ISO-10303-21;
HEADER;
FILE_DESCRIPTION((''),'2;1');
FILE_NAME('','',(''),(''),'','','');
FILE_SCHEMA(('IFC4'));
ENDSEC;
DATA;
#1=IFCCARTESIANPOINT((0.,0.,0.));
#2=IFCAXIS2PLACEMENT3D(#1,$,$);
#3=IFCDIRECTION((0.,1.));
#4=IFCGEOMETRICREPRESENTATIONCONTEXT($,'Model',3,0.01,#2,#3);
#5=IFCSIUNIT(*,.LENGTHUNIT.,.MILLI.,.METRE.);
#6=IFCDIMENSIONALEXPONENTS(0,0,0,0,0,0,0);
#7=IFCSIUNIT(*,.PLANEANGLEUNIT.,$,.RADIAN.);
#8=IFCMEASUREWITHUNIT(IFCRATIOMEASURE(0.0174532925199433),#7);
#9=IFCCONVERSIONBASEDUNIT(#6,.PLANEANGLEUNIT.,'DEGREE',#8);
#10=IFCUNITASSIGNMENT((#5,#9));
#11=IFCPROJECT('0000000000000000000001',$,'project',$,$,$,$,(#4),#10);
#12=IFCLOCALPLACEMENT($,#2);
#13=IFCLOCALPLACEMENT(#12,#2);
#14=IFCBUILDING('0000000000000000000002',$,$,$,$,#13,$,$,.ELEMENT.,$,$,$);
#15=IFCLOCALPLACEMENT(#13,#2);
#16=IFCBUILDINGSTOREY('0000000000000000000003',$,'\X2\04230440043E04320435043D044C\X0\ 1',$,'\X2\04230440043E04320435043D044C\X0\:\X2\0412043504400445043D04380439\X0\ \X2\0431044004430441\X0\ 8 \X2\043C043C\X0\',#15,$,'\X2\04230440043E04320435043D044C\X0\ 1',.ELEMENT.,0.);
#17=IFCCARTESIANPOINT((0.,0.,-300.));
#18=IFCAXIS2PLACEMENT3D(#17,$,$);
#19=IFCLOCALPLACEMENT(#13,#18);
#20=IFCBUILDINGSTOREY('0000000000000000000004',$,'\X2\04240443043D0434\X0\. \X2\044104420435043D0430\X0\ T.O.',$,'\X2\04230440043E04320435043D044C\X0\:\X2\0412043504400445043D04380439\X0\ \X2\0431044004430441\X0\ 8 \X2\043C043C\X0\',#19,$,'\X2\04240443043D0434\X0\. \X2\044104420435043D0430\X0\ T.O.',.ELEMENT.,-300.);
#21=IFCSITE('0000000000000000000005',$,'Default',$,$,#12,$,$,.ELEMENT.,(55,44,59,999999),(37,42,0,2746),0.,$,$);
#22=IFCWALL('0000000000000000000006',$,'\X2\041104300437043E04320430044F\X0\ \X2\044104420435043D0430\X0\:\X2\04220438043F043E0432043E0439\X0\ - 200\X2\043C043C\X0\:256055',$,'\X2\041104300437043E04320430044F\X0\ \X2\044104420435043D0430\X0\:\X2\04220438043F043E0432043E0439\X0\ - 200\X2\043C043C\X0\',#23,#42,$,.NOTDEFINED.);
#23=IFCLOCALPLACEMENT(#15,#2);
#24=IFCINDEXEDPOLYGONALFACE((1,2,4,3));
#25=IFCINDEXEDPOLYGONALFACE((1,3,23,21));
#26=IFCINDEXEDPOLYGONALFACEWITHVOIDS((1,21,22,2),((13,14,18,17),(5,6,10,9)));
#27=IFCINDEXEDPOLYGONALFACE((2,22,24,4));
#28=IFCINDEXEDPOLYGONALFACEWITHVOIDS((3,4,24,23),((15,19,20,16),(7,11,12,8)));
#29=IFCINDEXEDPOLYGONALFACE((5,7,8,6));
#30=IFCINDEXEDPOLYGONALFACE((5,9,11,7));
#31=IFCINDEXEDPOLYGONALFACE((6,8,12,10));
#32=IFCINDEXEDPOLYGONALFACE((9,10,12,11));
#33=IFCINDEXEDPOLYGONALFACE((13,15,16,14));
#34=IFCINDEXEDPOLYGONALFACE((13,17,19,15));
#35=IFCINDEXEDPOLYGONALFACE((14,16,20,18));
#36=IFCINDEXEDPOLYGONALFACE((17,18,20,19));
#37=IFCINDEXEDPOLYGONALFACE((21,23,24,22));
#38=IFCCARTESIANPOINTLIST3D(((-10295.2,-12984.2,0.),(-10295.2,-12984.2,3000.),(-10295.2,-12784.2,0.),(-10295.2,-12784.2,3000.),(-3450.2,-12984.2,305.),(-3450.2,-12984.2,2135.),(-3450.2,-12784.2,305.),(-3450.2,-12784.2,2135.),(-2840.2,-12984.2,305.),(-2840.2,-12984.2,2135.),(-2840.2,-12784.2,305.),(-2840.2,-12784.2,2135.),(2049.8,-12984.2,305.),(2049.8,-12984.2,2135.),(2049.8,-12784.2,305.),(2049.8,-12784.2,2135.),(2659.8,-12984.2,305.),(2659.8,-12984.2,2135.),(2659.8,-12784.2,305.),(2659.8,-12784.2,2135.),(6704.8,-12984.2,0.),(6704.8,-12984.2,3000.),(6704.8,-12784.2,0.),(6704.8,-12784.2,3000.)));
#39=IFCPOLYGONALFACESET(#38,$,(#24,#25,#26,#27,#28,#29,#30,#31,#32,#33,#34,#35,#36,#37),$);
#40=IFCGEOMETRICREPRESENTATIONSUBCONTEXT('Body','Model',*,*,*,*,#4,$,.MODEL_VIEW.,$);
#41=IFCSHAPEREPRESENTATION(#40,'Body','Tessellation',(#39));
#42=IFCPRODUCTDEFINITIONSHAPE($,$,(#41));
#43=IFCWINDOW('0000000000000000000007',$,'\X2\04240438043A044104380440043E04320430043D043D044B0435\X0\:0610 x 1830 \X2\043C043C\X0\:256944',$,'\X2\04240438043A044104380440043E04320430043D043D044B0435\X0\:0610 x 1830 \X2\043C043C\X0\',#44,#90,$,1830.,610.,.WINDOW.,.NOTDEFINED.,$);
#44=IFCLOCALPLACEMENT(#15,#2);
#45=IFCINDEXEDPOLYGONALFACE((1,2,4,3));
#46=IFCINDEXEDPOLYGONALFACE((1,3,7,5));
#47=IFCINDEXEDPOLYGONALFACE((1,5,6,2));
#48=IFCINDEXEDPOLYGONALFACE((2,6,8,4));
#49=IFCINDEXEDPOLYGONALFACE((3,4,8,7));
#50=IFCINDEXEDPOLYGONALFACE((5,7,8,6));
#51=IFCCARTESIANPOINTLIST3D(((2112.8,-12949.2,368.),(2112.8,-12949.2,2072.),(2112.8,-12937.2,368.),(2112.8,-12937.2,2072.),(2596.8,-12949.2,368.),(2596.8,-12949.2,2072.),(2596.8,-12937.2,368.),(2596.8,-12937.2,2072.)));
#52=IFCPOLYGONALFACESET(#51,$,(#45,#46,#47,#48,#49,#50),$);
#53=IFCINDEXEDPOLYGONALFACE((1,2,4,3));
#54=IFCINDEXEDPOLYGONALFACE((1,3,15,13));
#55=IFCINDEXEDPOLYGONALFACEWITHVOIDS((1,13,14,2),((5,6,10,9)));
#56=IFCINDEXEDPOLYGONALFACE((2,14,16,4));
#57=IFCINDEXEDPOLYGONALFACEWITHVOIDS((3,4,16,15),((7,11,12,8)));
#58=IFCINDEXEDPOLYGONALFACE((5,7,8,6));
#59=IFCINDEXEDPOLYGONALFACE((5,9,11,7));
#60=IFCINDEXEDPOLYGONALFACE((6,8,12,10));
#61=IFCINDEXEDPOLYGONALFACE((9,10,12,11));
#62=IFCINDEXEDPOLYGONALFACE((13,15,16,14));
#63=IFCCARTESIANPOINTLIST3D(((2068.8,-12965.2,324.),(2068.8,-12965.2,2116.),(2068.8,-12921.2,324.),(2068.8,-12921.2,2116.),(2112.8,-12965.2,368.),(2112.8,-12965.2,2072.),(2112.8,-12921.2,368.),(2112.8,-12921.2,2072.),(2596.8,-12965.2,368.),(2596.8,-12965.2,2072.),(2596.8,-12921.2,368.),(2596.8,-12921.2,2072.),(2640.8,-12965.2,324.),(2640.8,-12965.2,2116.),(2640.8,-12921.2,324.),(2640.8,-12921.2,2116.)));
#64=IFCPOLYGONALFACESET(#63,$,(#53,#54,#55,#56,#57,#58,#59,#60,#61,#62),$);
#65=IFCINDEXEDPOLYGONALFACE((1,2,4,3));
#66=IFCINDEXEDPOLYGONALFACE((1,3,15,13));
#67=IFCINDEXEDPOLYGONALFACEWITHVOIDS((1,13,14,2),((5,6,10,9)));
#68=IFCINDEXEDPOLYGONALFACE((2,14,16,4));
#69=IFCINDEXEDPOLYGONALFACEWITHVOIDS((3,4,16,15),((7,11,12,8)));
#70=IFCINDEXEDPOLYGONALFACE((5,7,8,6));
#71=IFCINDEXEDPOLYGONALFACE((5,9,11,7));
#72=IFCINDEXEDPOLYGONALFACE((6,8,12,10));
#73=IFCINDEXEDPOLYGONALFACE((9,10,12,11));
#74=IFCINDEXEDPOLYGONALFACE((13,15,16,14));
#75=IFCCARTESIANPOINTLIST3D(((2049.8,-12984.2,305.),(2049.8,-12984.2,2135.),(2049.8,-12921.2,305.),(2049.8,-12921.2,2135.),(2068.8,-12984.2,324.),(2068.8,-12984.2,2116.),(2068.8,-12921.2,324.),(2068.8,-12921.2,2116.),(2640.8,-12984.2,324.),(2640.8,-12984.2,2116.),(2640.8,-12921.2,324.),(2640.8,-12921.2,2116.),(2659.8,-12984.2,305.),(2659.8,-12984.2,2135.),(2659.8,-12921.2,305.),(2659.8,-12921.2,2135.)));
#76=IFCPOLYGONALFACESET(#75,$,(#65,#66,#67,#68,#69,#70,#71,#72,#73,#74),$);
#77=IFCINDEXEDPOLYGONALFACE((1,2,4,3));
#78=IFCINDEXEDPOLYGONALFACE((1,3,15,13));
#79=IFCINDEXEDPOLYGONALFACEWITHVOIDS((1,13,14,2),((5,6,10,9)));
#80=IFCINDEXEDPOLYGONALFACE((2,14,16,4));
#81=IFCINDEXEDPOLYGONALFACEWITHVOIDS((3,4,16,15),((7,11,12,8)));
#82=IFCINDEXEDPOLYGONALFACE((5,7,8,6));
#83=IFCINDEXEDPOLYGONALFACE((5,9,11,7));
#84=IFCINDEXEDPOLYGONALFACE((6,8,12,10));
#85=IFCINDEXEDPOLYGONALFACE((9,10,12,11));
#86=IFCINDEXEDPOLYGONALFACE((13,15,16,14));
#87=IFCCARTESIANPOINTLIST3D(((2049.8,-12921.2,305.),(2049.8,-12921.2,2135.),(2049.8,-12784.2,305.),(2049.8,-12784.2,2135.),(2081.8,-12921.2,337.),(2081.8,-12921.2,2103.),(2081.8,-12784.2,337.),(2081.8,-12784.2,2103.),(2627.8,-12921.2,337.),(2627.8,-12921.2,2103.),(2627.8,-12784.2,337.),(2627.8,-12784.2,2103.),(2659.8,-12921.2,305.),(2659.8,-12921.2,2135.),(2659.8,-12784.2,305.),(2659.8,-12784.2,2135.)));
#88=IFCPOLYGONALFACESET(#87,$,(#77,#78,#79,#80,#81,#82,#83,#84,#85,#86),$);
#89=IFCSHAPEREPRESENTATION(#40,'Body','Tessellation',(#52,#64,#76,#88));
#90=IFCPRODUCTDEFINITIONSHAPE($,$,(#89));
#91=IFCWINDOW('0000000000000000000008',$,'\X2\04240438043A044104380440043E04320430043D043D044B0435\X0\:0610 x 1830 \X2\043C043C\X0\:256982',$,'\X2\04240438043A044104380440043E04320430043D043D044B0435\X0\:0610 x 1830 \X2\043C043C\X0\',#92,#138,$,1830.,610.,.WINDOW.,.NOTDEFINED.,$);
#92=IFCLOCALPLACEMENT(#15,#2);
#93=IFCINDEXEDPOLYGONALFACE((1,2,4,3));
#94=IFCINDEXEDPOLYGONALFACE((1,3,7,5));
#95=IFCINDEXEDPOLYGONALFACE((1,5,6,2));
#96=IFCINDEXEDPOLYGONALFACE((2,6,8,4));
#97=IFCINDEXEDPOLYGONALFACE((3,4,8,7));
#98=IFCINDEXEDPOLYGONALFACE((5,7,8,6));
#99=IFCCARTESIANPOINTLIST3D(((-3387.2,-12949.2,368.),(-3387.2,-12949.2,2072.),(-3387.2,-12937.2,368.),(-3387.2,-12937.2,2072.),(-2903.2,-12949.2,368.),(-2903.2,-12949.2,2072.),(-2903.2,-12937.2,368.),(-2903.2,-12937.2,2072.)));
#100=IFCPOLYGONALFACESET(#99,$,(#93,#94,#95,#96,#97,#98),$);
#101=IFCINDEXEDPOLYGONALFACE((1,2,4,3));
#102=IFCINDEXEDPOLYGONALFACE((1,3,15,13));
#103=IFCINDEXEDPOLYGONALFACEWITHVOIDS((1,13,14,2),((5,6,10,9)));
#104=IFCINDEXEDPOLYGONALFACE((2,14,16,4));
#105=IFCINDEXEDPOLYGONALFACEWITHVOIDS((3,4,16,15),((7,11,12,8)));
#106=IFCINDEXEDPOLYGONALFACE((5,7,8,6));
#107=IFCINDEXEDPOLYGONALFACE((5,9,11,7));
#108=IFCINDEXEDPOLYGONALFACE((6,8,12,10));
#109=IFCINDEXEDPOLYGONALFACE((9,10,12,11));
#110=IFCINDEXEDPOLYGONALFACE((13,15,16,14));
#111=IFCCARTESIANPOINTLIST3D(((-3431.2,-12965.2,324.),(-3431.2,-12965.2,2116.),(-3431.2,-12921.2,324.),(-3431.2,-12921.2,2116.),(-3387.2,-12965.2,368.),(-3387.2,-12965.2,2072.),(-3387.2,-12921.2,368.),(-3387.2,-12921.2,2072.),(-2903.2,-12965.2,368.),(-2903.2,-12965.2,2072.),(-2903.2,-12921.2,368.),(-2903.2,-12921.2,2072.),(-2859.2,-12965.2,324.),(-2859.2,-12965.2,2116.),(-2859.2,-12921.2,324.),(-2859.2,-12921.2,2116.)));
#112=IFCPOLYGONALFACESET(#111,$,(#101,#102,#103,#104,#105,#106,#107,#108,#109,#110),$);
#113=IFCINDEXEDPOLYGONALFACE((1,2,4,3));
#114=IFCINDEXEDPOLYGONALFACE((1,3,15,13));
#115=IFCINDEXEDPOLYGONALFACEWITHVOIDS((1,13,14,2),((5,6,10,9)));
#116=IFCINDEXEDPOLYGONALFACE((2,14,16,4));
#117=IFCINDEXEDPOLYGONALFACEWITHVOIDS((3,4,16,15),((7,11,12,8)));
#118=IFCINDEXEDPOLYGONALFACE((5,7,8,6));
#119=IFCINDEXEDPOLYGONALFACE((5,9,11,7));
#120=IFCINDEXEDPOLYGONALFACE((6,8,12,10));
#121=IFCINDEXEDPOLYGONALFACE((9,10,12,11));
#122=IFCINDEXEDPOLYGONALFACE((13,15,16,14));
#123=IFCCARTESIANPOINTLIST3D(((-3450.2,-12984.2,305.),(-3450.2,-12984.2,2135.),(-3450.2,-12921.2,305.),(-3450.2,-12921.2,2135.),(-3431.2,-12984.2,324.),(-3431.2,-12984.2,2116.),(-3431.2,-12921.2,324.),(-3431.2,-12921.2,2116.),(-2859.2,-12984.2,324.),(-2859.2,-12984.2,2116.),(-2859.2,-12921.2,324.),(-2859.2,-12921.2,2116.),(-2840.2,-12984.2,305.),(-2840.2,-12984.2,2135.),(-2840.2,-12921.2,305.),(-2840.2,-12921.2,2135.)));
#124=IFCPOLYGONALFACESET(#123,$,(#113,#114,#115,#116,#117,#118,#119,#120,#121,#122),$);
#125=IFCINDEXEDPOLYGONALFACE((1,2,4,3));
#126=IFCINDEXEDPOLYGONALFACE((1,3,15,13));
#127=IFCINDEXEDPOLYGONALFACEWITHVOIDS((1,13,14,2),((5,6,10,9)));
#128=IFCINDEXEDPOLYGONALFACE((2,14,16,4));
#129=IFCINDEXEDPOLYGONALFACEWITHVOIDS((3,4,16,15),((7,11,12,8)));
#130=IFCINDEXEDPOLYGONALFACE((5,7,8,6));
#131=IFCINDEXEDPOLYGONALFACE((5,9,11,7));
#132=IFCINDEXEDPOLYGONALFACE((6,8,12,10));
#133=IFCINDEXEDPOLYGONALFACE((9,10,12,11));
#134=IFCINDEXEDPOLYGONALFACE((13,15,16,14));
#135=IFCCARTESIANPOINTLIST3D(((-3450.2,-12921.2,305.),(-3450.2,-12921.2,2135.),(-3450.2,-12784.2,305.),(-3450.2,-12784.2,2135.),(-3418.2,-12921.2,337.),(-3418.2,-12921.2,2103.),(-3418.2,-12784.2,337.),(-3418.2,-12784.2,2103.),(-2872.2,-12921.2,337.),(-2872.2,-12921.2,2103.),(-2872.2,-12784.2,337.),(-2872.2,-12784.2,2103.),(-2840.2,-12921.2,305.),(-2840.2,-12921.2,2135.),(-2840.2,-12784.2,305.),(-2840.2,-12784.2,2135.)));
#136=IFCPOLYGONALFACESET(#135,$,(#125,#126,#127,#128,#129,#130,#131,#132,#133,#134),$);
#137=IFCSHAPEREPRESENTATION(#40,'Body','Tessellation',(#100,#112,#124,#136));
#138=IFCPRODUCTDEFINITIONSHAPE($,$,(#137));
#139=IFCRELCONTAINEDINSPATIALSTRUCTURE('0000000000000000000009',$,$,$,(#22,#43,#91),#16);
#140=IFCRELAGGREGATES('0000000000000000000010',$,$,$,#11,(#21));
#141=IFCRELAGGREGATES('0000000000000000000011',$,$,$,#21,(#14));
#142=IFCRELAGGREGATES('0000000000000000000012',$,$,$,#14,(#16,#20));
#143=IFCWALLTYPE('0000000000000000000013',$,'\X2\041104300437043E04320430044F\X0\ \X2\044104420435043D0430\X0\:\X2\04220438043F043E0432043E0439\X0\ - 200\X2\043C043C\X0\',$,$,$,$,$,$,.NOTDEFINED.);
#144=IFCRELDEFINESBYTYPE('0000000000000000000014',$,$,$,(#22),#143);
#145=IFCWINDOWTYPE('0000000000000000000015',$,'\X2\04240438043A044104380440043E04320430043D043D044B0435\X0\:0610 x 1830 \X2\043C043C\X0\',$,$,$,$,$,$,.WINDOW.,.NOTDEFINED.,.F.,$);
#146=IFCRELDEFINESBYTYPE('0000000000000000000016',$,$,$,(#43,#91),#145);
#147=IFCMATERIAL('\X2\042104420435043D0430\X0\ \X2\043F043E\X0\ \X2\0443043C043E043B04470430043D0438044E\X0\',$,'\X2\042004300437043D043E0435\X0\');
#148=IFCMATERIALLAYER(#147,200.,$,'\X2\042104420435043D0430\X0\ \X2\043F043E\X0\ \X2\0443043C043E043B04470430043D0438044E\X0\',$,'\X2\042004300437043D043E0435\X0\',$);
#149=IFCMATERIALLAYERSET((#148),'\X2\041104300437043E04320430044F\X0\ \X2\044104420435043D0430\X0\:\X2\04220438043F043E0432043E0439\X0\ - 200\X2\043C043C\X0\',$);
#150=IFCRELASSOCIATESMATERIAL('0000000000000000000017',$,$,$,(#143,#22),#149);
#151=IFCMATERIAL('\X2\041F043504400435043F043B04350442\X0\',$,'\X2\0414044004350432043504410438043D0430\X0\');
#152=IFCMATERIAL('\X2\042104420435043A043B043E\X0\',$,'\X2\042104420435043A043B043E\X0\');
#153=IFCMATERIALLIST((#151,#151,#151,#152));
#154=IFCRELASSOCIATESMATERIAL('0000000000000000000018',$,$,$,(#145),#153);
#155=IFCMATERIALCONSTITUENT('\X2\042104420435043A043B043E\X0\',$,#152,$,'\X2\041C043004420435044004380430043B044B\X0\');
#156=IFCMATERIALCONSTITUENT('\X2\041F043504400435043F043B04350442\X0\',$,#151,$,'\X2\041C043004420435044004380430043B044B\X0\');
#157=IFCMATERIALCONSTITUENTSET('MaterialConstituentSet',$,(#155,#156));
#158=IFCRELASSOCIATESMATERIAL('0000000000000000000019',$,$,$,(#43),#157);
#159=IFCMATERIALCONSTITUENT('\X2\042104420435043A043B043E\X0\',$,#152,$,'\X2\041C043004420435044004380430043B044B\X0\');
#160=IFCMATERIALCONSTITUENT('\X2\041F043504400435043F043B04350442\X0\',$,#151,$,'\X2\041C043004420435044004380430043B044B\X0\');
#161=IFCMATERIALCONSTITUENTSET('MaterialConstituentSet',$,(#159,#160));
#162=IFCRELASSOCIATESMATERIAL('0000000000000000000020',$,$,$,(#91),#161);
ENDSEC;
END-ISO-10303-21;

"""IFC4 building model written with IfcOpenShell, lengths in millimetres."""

from ifc_helpers import new_model, entity, si_unit, converted_unit, direction, frame, frame_2d, origin, place, context, subcontext, project, spatial, polyline, rectangle, outline, extrude, source, transform, mapped, material, material_list, layer, layer_set, layer_usage, constituent, constituent_set, type_object, type_shapes, element, fill, save


model = new_model("IFC4")

# Units and contexts
model_context = context("Model", 3, precision=0.01, world=origin(), true_north=direction((0.0, 1.0)))
body_context = subcontext(model_context, "Body", "Model", "MODEL_VIEW")
ifc_project = project(units=[si_unit("LENGTHUNIT", "METRE", prefix="MILLI"), converted_unit("PLANEANGLEUNIT", "DEGREE", entity("IfcRatioMeasure", 0.0174532925199433), si_unit("PLANEANGLEUNIT", "RADIAN"), dimensions=[0, 0, 0, 0, 0, 0, 0])], contexts=[model_context])

# Site, building, storey
site_placement = place(None, origin())
site = spatial("IfcSite", under=ifc_project, at=site_placement, Name="Default", CompositionType="ELEMENT", RefLatitude=(55, 44, 59, 999999), RefLongitude=(37, 42, 0, 2746), RefElevation=0.0)
building_placement = place(site_placement, origin())
building = spatial("IfcBuilding", under=site, at=building_placement, CompositionType="ELEMENT")
storey_1_placement = place(building_placement, origin())
storey_1 = spatial("IfcBuildingStorey", under=building, at=storey_1_placement, Name="Уровень 1", ObjectType="Уровень:Верхний брус 8 мм", LongName="Уровень 1", CompositionType="ELEMENT", Elevation=0.0)

# Wall, openings, windows
ifc_material_1 = material(Name="Стена по умолчанию", Category="Разное")
ifc_layer = layer(ifc_material_1, 200.0, Name="Стена по умолчанию", Category="Разное")
ifc_layer_set = layer_set([ifc_layer], Name="Базовая стена:Типовой - 200мм")
wall_type = type_object("IfcWallType", Name="Базовая стена:Типовой - 200мм", PredefinedType="NOTDEFINED", material=ifc_layer_set)
ifc_material_2 = material(Name="Стекло", Category="Стекло")
ifc_material_3 = material(Name="Переплет", Category="Древесина")
ifc_material_list_1 = material_list([ifc_material_3, ifc_material_3, ifc_material_3, ifc_material_2])
window_type = type_object("IfcWindowType", Name="Фиксированные:0610 x 1830 мм", ParameterTakesPrecedence=False, PartitioningType="NOTDEFINED", PredefinedType="WINDOW", material=ifc_material_list_1)
shared_shape_1 = source(origin(), body_context, "Body", "SweptSolid", [
    extrude(rectangle(XDim=12.0, YDim=484.0, at=frame_2d((0.0, 0.0), x_axis=(1.0, 0.0))), frame((305.0, 159.0, 63.0), z_axis=(0.0, 0.0, 1.0), x_axis=(0.0, -1.0, 0.0)), (0.0, 0.0, 1.0), 1704.0),
    extrude(outline(polyline([(-286.0, -896.0), (286.0, -896.0), (286.0, 896.0), (-286.0, 896.0), (-286.0, -896.0)]), holes=[polyline([(-242.0, -852.0), (-242.0, 852.0), (242.0, 852.0), (242.0, -852.0), (-242.0, -852.0)])]), frame((305.0, 137.0, 915.0), z_axis=(0.0, 1.0, 0.0), x_axis=(1.0, 0.0, 0.0)), (0.0, 0.0, 1.0), 44.0),
    extrude(outline(polyline([(-305.0, -915.0), (305.0, -915.0), (305.0, 915.0), (-305.0, 915.0), (-305.0, -915.0)]), holes=[polyline([(-286.0, -896.0), (-286.0, 896.0), (286.0, 896.0), (286.0, -896.0), (-286.0, -896.0)])]), frame((305.0, 137.0, 915.0), z_axis=(0.0, 1.0, 0.0), x_axis=(1.0, 0.0, 0.0)), (0.0, 0.0, 1.0), 63.0),
    extrude(outline(polyline([(-305.0, -915.0), (305.0, -915.0), (305.0, 915.0), (-305.0, 915.0), (-305.0, -915.0)]), holes=[polyline([(-273.0, -883.0), (-273.0, 883.0), (273.0, 883.0), (273.0, -883.0), (-273.0, -883.0)])]), frame((305.0, 0.0, 915.0), z_axis=(0.0, 1.0, 0.0), x_axis=(1.0, 0.0, 0.0)), (0.0, 0.0, 1.0), 137.0),
])
type_shapes(window_type, [shared_shape_1])
ifc_layer_usage_1 = layer_usage(ifc_layer_set, "AXIS2", "NEGATIVE", 100.0)
wall_1_placement = place(storey_1_placement, frame((6704.8, -12884.2, 0.0), z_axis=(0.0, 0.0, 1.0), x_axis=(-1.0, 0.0, 0.0)))
wall_1 = element("IfcWall", 1, at=wall_1_placement, inside=storey_1, type_object=wall_type, material=ifc_layer_usage_1, Name="Базовая стена:Типовой - 200мм:256055", ObjectType="Базовая стена:Типовой - 200мм", PredefinedType="NOTDEFINED", context=body_context, shape_type="SweptSolid", body=[
    extrude(rectangle(XDim=17000.0, YDim=200.0, at=frame_2d((8500.0, 0.0), x_axis=(-1.0, 0.0))), origin(), (0.0, 0.0, 1.0), 3000.0),
])
opening_1_placement = place(wall_1_placement, frame((4045.0, -100.0, 305.0)))
opening_1 = element("IfcOpeningElement", 2, at=opening_1_placement, cuts=wall_1, ObjectType="Opening", PredefinedType="OPENING", context=body_context, shape_type="SweptSolid", body=[
    extrude(rectangle(XDim=1830.0, YDim=610.0, at=frame_2d((915.0, 305.0), x_axis=(1.0, 0.0))), frame((0.0, 0.0, 0.0), z_axis=(0.0, 1.0, 0.0), x_axis=(0.0, 0.0, 1.0)), (0.0, 0.0, 1.0), 200.0),
])
opening_2_placement = place(wall_1_placement, frame((9545.0, -100.0, 305.0)))
opening_2 = element("IfcOpeningElement", 3, at=opening_2_placement, cuts=wall_1, ObjectType="Opening", PredefinedType="OPENING", context=body_context, shape_type="SweptSolid", body=[
    extrude(rectangle(XDim=1830.0, YDim=610.0, at=frame_2d((915.0, 305.0), x_axis=(1.0, 0.0))), frame((0.0, 0.0, 0.0), z_axis=(0.0, 1.0, 0.0), x_axis=(0.0, 0.0, 1.0)), (0.0, 0.0, 1.0), 200.0),
])
ifc_constituent_1 = constituent(ifc_material_2, Name="Стекло", Category="Материалы")
ifc_constituent_2 = constituent(ifc_material_3, Name="Переплет", Category="Материалы")
ifc_constituent_set_1 = constituent_set(constituents=[ifc_constituent_1, ifc_constituent_2], Name="MaterialConstituentSet")
window_1_placement = place(opening_1_placement, origin())
window_1 = element("IfcWindow", 4, at=window_1_placement, inside=storey_1, type_object=window_type, material=ifc_constituent_set_1, Name="Фиксированные:0610 x 1830 мм:256944", ObjectType="Фиксированные:0610 x 1830 мм", OverallHeight=1830.0, OverallWidth=610.0, PartitioningType="NOTDEFINED", PredefinedType="WINDOW", context=body_context, shape_type="MappedRepresentation", body=[
    mapped(shared_shape_1, transform((0.0, 0.0, 0.0), scale=1.0)),
])
fill(opening_1, window_1)
ifc_constituent_3 = constituent(ifc_material_2, Name="Стекло", Category="Материалы")
ifc_constituent_4 = constituent(ifc_material_3, Name="Переплет", Category="Материалы")
ifc_constituent_set_2 = constituent_set(constituents=[ifc_constituent_3, ifc_constituent_4], Name="MaterialConstituentSet")
window_2_placement = place(opening_2_placement, origin())
window_2 = element("IfcWindow", 5, at=window_2_placement, inside=storey_1, type_object=window_type, material=ifc_constituent_set_2, Name="Фиксированные:0610 x 1830 мм:256982", ObjectType="Фиксированные:0610 x 1830 мм", OverallHeight=1830.0, OverallWidth=610.0, PartitioningType="NOTDEFINED", PredefinedType="WINDOW", context=body_context, shape_type="MappedRepresentation", body=[
    mapped(shared_shape_1, transform((0.0, 0.0, 0.0), scale=1.0)),
])
fill(opening_2, window_2)

# Shared definitions
storey_2_placement = place(building_placement, frame((0.0, 0.0, -300.0)))
storey_2 = spatial("IfcBuildingStorey", under=building, at=storey_2_placement, Name="Фунд. стена T.O.", ObjectType="Уровень:Верхний брус 8 мм", LongName="Фунд. стена T.O.", CompositionType="ELEMENT", Elevation=-300.0)

save(model, "model.ifc")
